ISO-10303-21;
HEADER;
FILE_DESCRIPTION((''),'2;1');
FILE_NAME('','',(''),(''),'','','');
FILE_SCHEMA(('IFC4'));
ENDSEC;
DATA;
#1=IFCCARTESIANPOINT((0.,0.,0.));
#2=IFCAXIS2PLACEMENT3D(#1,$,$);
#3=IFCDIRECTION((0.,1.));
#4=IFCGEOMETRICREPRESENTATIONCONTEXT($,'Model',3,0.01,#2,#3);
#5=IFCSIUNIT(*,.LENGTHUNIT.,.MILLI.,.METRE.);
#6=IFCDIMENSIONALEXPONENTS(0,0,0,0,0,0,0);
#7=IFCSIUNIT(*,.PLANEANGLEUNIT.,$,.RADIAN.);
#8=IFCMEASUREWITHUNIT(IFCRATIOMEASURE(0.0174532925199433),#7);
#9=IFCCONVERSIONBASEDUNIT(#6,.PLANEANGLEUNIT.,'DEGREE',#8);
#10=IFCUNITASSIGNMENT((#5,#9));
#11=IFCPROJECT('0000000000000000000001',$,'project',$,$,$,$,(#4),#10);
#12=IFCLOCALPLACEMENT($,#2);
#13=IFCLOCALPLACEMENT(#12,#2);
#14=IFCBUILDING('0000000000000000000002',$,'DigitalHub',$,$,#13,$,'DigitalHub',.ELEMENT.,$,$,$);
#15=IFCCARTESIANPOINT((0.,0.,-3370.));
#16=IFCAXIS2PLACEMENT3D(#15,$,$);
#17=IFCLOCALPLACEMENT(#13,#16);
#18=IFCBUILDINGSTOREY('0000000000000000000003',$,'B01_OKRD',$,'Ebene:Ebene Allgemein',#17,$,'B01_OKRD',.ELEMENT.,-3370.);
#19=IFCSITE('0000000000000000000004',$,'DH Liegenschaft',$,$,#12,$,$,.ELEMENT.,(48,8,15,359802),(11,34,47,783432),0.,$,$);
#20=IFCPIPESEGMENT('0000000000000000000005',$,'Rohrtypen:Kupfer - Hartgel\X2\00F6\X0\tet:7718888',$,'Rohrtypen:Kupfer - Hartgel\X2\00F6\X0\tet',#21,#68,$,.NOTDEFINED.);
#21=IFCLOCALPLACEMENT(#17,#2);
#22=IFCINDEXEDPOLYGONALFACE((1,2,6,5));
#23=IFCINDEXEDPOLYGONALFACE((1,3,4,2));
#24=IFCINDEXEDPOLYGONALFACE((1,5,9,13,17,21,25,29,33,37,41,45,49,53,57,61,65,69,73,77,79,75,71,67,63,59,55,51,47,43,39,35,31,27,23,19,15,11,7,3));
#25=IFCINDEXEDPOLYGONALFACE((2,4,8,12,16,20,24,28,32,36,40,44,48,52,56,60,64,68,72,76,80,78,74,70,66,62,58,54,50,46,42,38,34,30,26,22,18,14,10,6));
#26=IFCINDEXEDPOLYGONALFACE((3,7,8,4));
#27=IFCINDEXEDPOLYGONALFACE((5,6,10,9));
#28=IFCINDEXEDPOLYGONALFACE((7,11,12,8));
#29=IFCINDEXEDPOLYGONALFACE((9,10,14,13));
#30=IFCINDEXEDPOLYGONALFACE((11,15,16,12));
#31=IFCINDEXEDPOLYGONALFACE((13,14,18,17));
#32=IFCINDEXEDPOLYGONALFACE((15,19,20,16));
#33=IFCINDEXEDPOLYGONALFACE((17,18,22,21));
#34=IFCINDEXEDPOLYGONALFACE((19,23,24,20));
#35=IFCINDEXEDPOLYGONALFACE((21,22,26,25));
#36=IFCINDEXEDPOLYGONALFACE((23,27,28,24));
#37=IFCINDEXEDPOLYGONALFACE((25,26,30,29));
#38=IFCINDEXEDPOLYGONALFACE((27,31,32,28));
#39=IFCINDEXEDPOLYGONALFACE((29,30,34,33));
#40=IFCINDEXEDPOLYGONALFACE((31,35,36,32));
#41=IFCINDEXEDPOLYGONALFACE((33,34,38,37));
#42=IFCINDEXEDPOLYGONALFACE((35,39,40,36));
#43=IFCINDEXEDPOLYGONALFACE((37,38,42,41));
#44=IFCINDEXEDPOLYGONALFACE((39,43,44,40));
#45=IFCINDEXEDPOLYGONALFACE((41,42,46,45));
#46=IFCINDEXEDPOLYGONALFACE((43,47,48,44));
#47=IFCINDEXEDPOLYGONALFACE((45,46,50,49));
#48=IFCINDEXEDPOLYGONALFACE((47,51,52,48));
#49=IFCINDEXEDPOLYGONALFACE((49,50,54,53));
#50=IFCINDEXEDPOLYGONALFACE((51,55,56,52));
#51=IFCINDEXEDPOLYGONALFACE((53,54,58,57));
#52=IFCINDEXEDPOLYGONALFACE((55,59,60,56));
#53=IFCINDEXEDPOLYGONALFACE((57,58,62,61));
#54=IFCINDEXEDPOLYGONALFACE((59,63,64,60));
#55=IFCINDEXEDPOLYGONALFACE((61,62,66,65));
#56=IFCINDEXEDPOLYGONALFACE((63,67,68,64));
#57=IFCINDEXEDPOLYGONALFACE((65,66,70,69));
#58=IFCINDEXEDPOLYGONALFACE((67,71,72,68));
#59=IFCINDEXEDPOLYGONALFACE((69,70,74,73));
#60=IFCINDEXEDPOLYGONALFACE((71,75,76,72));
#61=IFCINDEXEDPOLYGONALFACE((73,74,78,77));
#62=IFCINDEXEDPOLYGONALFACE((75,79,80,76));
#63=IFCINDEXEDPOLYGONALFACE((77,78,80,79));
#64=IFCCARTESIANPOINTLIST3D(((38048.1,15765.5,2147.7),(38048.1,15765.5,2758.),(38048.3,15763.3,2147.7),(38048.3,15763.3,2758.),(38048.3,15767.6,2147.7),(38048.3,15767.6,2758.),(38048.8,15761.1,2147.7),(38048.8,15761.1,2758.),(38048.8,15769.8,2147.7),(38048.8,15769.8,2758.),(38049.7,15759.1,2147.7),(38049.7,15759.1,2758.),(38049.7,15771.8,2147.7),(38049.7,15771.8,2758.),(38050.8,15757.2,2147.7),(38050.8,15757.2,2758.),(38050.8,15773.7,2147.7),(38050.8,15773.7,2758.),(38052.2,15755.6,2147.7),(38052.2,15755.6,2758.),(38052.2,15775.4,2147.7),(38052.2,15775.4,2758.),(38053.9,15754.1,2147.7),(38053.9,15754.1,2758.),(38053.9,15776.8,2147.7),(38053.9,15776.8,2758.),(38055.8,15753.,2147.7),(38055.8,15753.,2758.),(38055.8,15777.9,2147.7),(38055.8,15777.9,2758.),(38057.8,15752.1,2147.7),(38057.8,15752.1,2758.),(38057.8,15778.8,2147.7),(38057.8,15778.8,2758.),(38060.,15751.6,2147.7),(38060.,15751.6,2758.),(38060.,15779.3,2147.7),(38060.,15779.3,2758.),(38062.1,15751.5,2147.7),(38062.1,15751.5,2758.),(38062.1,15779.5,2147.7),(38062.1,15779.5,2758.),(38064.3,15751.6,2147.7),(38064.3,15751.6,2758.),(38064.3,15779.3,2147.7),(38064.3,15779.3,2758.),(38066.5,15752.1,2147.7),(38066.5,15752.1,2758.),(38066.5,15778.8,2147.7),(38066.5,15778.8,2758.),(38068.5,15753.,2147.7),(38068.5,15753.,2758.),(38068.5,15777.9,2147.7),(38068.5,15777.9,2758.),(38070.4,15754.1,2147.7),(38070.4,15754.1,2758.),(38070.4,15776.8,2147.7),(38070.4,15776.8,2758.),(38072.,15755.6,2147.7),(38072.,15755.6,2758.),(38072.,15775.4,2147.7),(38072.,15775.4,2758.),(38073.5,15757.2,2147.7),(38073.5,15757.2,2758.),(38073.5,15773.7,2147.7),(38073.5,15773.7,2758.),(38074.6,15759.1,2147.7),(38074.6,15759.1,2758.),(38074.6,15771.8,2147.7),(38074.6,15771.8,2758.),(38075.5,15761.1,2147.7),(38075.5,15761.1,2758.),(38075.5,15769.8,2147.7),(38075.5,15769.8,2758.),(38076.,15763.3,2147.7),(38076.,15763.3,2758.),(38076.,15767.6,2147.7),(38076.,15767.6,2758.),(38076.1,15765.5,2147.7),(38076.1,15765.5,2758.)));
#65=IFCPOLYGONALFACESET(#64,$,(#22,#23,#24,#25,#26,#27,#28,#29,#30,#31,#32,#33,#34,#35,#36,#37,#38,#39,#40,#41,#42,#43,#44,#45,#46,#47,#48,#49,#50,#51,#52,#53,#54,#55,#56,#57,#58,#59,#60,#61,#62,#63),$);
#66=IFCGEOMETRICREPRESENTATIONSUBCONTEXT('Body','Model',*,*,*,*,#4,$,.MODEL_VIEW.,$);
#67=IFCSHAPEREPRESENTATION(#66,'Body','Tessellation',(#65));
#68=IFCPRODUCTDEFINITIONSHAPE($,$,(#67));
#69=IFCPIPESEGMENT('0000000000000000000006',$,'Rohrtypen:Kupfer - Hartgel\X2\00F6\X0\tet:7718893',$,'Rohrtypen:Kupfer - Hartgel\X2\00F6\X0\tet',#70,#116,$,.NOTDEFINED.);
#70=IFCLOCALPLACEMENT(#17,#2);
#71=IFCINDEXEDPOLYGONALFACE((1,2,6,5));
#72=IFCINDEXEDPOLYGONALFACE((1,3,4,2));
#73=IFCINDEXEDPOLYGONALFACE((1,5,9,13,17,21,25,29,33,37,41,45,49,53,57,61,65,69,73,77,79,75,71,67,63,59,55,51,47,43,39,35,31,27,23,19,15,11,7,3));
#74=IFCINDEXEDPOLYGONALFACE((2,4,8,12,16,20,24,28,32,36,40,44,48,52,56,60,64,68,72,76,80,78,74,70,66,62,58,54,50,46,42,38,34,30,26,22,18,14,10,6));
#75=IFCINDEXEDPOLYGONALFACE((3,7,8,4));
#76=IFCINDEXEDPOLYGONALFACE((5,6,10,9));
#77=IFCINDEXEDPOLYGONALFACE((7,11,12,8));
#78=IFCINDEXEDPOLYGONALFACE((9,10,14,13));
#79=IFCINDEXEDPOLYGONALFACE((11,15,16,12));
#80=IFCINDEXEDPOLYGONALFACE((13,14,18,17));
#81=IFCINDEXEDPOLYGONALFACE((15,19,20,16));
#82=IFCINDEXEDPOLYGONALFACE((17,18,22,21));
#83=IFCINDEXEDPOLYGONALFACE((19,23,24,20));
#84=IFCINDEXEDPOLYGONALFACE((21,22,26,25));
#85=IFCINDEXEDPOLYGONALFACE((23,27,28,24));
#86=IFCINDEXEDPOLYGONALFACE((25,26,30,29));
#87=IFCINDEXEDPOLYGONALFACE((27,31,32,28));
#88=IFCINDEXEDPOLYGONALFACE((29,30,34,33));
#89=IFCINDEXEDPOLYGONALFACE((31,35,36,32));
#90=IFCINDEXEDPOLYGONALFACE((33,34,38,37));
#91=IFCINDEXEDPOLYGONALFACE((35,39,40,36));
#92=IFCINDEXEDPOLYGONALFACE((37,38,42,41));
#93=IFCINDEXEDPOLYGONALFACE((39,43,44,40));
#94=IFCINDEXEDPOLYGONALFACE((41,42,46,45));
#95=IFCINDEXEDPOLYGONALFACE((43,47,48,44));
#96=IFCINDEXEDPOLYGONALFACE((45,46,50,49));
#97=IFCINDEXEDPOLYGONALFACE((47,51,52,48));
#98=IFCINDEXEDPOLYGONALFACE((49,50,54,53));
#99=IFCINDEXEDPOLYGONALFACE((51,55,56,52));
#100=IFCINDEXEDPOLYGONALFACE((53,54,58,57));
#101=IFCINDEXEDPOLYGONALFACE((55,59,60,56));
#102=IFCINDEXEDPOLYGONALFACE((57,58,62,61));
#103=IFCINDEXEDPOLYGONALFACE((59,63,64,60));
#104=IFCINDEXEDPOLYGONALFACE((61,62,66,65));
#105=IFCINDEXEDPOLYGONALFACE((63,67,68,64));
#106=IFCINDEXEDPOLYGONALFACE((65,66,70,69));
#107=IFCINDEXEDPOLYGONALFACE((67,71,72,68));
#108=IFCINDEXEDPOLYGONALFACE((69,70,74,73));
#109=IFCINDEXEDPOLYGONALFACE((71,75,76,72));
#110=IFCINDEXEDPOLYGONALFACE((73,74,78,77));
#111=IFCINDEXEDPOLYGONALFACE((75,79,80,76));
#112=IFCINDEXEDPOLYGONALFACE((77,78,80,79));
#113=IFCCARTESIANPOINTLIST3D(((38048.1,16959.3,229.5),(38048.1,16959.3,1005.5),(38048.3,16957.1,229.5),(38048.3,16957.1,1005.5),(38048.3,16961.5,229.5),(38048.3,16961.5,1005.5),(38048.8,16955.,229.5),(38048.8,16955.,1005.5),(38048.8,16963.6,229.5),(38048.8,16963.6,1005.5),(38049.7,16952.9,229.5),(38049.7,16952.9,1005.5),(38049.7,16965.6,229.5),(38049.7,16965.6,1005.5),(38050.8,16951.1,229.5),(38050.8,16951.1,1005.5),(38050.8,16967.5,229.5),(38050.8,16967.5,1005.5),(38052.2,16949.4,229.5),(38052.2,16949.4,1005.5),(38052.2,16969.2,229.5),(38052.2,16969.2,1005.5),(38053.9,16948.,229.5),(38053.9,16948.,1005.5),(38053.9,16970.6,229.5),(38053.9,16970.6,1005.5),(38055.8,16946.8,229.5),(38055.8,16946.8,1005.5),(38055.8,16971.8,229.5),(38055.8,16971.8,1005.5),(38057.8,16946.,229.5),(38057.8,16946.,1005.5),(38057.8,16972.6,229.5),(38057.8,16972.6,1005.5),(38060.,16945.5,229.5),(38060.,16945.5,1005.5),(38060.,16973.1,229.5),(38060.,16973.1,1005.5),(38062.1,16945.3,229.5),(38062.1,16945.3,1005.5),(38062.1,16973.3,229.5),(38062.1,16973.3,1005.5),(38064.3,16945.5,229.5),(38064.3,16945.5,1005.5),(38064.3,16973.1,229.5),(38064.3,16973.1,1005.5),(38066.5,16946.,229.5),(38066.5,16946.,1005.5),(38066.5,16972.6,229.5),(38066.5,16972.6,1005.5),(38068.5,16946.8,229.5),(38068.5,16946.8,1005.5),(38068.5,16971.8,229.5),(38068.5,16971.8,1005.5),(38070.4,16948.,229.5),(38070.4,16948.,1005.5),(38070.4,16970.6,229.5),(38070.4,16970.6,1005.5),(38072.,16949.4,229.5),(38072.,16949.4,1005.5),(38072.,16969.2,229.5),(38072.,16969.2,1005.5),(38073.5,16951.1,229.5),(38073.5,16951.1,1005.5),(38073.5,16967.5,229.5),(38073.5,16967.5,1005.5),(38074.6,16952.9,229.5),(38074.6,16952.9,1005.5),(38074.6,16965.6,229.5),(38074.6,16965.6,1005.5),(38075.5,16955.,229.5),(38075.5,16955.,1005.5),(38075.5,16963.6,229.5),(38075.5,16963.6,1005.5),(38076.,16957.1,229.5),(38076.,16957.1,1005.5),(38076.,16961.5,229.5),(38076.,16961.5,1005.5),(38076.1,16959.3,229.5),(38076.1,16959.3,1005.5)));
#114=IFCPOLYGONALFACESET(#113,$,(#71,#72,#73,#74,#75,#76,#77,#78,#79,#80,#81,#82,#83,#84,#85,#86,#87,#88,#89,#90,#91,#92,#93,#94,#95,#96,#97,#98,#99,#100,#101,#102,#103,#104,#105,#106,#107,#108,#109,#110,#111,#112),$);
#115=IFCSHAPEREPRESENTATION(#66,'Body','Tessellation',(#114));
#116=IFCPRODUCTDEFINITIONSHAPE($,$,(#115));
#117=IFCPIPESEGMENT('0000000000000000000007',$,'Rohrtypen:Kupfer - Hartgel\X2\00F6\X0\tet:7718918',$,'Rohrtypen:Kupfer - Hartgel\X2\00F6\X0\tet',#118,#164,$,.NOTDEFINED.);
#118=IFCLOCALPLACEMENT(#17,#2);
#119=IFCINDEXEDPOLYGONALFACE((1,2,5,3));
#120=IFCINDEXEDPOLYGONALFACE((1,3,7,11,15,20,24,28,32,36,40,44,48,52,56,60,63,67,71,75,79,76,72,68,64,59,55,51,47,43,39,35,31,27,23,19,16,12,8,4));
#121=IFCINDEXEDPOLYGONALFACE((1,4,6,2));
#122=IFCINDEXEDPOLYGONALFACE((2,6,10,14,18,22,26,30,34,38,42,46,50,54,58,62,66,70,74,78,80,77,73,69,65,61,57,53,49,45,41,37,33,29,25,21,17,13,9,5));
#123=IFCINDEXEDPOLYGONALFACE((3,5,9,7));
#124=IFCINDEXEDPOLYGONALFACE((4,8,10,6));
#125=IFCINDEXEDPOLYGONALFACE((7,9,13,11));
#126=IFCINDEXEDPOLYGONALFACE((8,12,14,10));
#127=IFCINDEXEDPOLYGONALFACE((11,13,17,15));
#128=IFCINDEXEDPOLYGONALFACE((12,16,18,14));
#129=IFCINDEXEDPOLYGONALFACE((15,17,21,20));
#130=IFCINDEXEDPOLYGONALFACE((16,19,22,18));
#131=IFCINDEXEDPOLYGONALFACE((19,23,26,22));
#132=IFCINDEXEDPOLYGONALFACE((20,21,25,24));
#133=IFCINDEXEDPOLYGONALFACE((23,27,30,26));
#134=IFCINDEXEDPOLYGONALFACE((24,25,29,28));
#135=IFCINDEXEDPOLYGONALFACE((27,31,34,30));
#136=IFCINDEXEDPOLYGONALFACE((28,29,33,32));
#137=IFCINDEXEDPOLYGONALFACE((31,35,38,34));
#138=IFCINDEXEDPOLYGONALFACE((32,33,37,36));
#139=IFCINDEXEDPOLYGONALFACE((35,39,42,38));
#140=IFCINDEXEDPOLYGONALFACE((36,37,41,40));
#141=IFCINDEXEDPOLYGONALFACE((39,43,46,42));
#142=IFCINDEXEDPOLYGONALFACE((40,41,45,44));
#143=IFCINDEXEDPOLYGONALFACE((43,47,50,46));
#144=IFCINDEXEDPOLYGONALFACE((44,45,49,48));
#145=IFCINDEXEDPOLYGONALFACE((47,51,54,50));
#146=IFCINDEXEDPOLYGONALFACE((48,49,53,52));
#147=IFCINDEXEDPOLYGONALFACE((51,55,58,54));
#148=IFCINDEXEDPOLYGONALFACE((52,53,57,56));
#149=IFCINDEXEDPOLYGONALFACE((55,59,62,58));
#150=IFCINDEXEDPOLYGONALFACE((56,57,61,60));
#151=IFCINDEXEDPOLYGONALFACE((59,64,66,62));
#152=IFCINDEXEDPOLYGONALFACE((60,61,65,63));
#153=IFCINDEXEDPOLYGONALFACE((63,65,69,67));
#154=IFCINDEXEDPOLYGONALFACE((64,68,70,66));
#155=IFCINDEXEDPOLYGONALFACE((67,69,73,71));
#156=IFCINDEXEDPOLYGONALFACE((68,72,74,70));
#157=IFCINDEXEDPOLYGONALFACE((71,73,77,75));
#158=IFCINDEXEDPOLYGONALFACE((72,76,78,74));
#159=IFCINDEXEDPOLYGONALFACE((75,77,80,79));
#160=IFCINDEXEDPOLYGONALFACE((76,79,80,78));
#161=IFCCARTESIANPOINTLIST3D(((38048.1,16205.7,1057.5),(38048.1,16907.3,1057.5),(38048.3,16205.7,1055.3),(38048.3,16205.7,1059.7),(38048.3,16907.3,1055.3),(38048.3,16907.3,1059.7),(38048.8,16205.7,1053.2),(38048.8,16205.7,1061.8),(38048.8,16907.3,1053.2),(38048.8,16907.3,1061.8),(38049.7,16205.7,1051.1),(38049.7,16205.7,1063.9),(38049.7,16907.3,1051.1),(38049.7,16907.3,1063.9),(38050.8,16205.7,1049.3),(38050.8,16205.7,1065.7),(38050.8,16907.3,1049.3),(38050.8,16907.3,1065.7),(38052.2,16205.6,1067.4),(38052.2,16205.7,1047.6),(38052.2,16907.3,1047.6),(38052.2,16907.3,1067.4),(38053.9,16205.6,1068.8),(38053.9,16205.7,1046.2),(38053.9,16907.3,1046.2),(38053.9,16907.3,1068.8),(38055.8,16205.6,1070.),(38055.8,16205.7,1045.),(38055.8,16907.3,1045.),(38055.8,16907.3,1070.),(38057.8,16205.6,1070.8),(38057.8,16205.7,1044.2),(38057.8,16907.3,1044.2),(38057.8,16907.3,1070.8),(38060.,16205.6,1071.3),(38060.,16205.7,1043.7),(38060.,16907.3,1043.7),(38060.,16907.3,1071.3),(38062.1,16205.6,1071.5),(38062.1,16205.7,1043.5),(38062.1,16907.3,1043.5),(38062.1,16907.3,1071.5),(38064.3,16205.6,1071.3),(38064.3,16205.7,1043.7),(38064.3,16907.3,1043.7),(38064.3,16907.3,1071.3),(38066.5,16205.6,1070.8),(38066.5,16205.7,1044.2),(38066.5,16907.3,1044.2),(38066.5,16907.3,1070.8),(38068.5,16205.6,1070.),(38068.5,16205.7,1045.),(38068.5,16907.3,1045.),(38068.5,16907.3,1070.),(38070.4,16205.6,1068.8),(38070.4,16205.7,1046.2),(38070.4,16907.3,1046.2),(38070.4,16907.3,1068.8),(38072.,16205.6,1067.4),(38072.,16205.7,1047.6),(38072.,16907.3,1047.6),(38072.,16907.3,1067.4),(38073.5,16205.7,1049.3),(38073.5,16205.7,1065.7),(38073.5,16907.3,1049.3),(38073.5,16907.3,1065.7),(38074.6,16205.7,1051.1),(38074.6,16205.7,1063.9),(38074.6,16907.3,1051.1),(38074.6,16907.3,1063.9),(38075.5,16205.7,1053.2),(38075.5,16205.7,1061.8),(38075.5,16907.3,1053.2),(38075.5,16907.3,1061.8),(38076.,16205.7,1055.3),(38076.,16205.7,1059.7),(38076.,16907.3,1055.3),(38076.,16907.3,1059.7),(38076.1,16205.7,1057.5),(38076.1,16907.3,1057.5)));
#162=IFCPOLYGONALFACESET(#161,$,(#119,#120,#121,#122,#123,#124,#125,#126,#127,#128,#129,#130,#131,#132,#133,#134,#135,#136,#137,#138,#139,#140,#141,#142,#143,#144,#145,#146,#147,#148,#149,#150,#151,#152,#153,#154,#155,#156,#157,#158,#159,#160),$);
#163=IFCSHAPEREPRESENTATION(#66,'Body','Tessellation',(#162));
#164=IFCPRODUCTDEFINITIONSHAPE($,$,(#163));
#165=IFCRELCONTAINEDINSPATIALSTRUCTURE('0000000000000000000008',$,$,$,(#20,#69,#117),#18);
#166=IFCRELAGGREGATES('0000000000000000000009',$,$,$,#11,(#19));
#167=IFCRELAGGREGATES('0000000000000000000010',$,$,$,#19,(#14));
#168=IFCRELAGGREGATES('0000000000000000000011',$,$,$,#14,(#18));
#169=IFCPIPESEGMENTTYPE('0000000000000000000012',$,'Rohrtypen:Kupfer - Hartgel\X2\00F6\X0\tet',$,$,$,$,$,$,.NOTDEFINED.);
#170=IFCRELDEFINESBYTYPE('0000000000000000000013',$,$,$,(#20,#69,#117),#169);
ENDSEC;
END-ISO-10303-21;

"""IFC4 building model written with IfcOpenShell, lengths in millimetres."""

from ifc_helpers import new_model, entity, si_unit, converted_unit, direction, frame, origin, place, context, subcontext, project, spatial, indexed_curve, outline, extrude, type_object, element, save


model = new_model("IFC4")

# Units and contexts
model_context = context("Model", 3, precision=0.01, world=origin(), true_north=direction((0.0, 1.0)))
body_context = subcontext(model_context, "Body", "Model", "MODEL_VIEW")
ifc_project = project(units=[si_unit("LENGTHUNIT", "METRE", prefix="MILLI"), converted_unit("PLANEANGLEUNIT", "DEGREE", entity("IfcRatioMeasure", 0.0174532925199433), si_unit("PLANEANGLEUNIT", "RADIAN"), dimensions=[0, 0, 0, 0, 0, 0, 0])], contexts=[model_context])

# Site, building, storey
site_placement = place(None, origin())
site = spatial("IfcSite", under=ifc_project, at=site_placement, Name="DH Liegenschaft", CompositionType="ELEMENT", RefLatitude=(48, 8, 15, 359802), RefLongitude=(11, 34, 47, 783432), RefElevation=0.0)
building_placement = place(site_placement, origin())
building = spatial("IfcBuilding", under=site, at=building_placement, Name="DigitalHub", LongName="DigitalHub", CompositionType="ELEMENT")
storey_placement = place(building_placement, frame((0.0, 0.0, -3370.0)))
storey = spatial("IfcBuildingStorey", under=building, at=storey_placement, Name="B01_OKRD", ObjectType="Ebene:Ebene Allgemein", LongName="B01_OKRD", CompositionType="ELEMENT", Elevation=-3370.0)

# Pipe segments
pipe_segment_type = type_object("IfcPipeSegmentType", Name="Rohrtypen:Kupfer - Hartgelötet", PredefinedType="NOTDEFINED")
pipe_segment_1_placement = place(storey_placement, frame((38046.6, 15749.9, 2147.7)))
element("IfcPipeSegment", 1, at=pipe_segment_1_placement, inside=storey, type_object=pipe_segment_type, Name="Rohrtypen:Kupfer - Hartgelötet:7718888", ObjectType="Rohrtypen:Kupfer - Hartgelötet", PredefinedType="NOTDEFINED", context=body_context, shape_type="SweptSolid", body=[
    extrude(outline(indexed_curve([(14.0, 0.0), (13.8, 2.2), (13.3, 4.3), (12.5, 6.4), (11.3, 8.2), (9.9, 9.9), (8.2, 11.3), (6.4, 12.5), (4.3, 13.3), (2.2, 13.8), (0.0, 14.0), (-2.2, 13.8), (-4.3, 13.3), (-6.4, 12.5), (-8.2, 11.3), (-9.9, 9.9), (-11.3, 8.2), (-12.5, 6.4), (-13.3, 4.3), (-13.8, 2.2), (-14.0, 0.0), (-13.8, -2.2), (-13.3, -4.3), (-12.5, -6.4), (-11.3, -8.2), (-9.9, -9.9), (-8.2, -11.3), (-6.4, -12.5), (-4.3, -13.3), (-2.2, -13.8), (0.0, -14.0), (2.2, -13.8), (4.3, -13.3), (6.4, -12.5), (8.2, -11.3), (9.9, -9.9), (11.3, -8.2), (12.5, -6.4), (13.3, -4.3), (13.8, -2.2), (14.0, 0.0)], self_intersect=False)), frame((15.6, 15.6, 0.0)), (0.0, 0.0, 1.0), 610.3),
])
pipe_segment_2_placement = place(storey_placement, frame((38046.6, 16943.7, 229.5)))
element("IfcPipeSegment", 2, at=pipe_segment_2_placement, inside=storey, type_object=pipe_segment_type, Name="Rohrtypen:Kupfer - Hartgelötet:7718893", ObjectType="Rohrtypen:Kupfer - Hartgelötet", PredefinedType="NOTDEFINED", context=body_context, shape_type="SweptSolid", body=[
    extrude(outline(indexed_curve([(14.0, 0.0), (13.8, 2.2), (13.3, 4.3), (12.5, 6.4), (11.3, 8.2), (9.9, 9.9), (8.2, 11.3), (6.4, 12.5), (4.3, 13.3), (2.2, 13.8), (0.0, 14.0), (-2.2, 13.8), (-4.3, 13.3), (-6.4, 12.5), (-8.2, 11.3), (-9.9, 9.9), (-11.3, 8.2), (-12.5, 6.4), (-13.3, 4.3), (-13.8, 2.2), (-14.0, 0.0), (-13.8, -2.2), (-13.3, -4.3), (-12.5, -6.4), (-11.3, -8.2), (-9.9, -9.9), (-8.2, -11.3), (-6.4, -12.5), (-4.3, -13.3), (-2.2, -13.8), (0.0, -14.0), (2.2, -13.8), (4.3, -13.3), (6.4, -12.5), (8.2, -11.3), (9.9, -9.9), (11.3, -8.2), (12.5, -6.4), (13.3, -4.3), (13.8, -2.2), (14.0, 0.0)], self_intersect=False)), frame((15.6, 15.6, 0.0), z_axis=(0.0, 0.0, 1.0), x_axis=(-1.0, 0.0, 0.0)), (0.0, 0.0, 1.0), 776.0),
])
pipe_segment_3_placement = place(storey_placement, frame((38046.6, 16205.6, 1041.9)))
element("IfcPipeSegment", 3, at=pipe_segment_3_placement, inside=storey, type_object=pipe_segment_type, Name="Rohrtypen:Kupfer - Hartgelötet:7718918", ObjectType="Rohrtypen:Kupfer - Hartgelötet", PredefinedType="NOTDEFINED", context=body_context, shape_type="SweptSolid", body=[
    extrude(outline(indexed_curve([(14.0, 0.0), (13.8, 2.2), (13.3, 4.3), (12.5, 6.4), (11.3, 8.2), (9.9, 9.9), (8.2, 11.3), (6.4, 12.5), (4.3, 13.3), (2.2, 13.8), (0.0, 14.0), (-2.2, 13.8), (-4.3, 13.3), (-6.4, 12.5), (-8.2, 11.3), (-9.9, 9.9), (-11.3, 8.2), (-12.5, 6.4), (-13.3, 4.3), (-13.8, 2.2), (-14.0, 0.0), (-13.8, -2.2), (-13.3, -4.3), (-12.5, -6.4), (-11.3, -8.2), (-9.9, -9.9), (-8.2, -11.3), (-6.4, -12.5), (-4.3, -13.3), (-2.2, -13.8), (0.0, -14.0), (2.2, -13.8), (4.3, -13.3), (6.4, -12.5), (8.2, -11.3), (9.9, -9.9), (11.3, -8.2), (12.5, -6.4), (13.3, -4.3), (13.8, -2.2), (14.0, 0.0)], self_intersect=False)), frame((15.6, 0.0, 15.6), z_axis=(0.0, 1.0, 0.000005), x_axis=(1.0, 0.0, 0.0)), (0.0, 0.0, 1.0), 701.6),
])

save(model, "model.ifc")
